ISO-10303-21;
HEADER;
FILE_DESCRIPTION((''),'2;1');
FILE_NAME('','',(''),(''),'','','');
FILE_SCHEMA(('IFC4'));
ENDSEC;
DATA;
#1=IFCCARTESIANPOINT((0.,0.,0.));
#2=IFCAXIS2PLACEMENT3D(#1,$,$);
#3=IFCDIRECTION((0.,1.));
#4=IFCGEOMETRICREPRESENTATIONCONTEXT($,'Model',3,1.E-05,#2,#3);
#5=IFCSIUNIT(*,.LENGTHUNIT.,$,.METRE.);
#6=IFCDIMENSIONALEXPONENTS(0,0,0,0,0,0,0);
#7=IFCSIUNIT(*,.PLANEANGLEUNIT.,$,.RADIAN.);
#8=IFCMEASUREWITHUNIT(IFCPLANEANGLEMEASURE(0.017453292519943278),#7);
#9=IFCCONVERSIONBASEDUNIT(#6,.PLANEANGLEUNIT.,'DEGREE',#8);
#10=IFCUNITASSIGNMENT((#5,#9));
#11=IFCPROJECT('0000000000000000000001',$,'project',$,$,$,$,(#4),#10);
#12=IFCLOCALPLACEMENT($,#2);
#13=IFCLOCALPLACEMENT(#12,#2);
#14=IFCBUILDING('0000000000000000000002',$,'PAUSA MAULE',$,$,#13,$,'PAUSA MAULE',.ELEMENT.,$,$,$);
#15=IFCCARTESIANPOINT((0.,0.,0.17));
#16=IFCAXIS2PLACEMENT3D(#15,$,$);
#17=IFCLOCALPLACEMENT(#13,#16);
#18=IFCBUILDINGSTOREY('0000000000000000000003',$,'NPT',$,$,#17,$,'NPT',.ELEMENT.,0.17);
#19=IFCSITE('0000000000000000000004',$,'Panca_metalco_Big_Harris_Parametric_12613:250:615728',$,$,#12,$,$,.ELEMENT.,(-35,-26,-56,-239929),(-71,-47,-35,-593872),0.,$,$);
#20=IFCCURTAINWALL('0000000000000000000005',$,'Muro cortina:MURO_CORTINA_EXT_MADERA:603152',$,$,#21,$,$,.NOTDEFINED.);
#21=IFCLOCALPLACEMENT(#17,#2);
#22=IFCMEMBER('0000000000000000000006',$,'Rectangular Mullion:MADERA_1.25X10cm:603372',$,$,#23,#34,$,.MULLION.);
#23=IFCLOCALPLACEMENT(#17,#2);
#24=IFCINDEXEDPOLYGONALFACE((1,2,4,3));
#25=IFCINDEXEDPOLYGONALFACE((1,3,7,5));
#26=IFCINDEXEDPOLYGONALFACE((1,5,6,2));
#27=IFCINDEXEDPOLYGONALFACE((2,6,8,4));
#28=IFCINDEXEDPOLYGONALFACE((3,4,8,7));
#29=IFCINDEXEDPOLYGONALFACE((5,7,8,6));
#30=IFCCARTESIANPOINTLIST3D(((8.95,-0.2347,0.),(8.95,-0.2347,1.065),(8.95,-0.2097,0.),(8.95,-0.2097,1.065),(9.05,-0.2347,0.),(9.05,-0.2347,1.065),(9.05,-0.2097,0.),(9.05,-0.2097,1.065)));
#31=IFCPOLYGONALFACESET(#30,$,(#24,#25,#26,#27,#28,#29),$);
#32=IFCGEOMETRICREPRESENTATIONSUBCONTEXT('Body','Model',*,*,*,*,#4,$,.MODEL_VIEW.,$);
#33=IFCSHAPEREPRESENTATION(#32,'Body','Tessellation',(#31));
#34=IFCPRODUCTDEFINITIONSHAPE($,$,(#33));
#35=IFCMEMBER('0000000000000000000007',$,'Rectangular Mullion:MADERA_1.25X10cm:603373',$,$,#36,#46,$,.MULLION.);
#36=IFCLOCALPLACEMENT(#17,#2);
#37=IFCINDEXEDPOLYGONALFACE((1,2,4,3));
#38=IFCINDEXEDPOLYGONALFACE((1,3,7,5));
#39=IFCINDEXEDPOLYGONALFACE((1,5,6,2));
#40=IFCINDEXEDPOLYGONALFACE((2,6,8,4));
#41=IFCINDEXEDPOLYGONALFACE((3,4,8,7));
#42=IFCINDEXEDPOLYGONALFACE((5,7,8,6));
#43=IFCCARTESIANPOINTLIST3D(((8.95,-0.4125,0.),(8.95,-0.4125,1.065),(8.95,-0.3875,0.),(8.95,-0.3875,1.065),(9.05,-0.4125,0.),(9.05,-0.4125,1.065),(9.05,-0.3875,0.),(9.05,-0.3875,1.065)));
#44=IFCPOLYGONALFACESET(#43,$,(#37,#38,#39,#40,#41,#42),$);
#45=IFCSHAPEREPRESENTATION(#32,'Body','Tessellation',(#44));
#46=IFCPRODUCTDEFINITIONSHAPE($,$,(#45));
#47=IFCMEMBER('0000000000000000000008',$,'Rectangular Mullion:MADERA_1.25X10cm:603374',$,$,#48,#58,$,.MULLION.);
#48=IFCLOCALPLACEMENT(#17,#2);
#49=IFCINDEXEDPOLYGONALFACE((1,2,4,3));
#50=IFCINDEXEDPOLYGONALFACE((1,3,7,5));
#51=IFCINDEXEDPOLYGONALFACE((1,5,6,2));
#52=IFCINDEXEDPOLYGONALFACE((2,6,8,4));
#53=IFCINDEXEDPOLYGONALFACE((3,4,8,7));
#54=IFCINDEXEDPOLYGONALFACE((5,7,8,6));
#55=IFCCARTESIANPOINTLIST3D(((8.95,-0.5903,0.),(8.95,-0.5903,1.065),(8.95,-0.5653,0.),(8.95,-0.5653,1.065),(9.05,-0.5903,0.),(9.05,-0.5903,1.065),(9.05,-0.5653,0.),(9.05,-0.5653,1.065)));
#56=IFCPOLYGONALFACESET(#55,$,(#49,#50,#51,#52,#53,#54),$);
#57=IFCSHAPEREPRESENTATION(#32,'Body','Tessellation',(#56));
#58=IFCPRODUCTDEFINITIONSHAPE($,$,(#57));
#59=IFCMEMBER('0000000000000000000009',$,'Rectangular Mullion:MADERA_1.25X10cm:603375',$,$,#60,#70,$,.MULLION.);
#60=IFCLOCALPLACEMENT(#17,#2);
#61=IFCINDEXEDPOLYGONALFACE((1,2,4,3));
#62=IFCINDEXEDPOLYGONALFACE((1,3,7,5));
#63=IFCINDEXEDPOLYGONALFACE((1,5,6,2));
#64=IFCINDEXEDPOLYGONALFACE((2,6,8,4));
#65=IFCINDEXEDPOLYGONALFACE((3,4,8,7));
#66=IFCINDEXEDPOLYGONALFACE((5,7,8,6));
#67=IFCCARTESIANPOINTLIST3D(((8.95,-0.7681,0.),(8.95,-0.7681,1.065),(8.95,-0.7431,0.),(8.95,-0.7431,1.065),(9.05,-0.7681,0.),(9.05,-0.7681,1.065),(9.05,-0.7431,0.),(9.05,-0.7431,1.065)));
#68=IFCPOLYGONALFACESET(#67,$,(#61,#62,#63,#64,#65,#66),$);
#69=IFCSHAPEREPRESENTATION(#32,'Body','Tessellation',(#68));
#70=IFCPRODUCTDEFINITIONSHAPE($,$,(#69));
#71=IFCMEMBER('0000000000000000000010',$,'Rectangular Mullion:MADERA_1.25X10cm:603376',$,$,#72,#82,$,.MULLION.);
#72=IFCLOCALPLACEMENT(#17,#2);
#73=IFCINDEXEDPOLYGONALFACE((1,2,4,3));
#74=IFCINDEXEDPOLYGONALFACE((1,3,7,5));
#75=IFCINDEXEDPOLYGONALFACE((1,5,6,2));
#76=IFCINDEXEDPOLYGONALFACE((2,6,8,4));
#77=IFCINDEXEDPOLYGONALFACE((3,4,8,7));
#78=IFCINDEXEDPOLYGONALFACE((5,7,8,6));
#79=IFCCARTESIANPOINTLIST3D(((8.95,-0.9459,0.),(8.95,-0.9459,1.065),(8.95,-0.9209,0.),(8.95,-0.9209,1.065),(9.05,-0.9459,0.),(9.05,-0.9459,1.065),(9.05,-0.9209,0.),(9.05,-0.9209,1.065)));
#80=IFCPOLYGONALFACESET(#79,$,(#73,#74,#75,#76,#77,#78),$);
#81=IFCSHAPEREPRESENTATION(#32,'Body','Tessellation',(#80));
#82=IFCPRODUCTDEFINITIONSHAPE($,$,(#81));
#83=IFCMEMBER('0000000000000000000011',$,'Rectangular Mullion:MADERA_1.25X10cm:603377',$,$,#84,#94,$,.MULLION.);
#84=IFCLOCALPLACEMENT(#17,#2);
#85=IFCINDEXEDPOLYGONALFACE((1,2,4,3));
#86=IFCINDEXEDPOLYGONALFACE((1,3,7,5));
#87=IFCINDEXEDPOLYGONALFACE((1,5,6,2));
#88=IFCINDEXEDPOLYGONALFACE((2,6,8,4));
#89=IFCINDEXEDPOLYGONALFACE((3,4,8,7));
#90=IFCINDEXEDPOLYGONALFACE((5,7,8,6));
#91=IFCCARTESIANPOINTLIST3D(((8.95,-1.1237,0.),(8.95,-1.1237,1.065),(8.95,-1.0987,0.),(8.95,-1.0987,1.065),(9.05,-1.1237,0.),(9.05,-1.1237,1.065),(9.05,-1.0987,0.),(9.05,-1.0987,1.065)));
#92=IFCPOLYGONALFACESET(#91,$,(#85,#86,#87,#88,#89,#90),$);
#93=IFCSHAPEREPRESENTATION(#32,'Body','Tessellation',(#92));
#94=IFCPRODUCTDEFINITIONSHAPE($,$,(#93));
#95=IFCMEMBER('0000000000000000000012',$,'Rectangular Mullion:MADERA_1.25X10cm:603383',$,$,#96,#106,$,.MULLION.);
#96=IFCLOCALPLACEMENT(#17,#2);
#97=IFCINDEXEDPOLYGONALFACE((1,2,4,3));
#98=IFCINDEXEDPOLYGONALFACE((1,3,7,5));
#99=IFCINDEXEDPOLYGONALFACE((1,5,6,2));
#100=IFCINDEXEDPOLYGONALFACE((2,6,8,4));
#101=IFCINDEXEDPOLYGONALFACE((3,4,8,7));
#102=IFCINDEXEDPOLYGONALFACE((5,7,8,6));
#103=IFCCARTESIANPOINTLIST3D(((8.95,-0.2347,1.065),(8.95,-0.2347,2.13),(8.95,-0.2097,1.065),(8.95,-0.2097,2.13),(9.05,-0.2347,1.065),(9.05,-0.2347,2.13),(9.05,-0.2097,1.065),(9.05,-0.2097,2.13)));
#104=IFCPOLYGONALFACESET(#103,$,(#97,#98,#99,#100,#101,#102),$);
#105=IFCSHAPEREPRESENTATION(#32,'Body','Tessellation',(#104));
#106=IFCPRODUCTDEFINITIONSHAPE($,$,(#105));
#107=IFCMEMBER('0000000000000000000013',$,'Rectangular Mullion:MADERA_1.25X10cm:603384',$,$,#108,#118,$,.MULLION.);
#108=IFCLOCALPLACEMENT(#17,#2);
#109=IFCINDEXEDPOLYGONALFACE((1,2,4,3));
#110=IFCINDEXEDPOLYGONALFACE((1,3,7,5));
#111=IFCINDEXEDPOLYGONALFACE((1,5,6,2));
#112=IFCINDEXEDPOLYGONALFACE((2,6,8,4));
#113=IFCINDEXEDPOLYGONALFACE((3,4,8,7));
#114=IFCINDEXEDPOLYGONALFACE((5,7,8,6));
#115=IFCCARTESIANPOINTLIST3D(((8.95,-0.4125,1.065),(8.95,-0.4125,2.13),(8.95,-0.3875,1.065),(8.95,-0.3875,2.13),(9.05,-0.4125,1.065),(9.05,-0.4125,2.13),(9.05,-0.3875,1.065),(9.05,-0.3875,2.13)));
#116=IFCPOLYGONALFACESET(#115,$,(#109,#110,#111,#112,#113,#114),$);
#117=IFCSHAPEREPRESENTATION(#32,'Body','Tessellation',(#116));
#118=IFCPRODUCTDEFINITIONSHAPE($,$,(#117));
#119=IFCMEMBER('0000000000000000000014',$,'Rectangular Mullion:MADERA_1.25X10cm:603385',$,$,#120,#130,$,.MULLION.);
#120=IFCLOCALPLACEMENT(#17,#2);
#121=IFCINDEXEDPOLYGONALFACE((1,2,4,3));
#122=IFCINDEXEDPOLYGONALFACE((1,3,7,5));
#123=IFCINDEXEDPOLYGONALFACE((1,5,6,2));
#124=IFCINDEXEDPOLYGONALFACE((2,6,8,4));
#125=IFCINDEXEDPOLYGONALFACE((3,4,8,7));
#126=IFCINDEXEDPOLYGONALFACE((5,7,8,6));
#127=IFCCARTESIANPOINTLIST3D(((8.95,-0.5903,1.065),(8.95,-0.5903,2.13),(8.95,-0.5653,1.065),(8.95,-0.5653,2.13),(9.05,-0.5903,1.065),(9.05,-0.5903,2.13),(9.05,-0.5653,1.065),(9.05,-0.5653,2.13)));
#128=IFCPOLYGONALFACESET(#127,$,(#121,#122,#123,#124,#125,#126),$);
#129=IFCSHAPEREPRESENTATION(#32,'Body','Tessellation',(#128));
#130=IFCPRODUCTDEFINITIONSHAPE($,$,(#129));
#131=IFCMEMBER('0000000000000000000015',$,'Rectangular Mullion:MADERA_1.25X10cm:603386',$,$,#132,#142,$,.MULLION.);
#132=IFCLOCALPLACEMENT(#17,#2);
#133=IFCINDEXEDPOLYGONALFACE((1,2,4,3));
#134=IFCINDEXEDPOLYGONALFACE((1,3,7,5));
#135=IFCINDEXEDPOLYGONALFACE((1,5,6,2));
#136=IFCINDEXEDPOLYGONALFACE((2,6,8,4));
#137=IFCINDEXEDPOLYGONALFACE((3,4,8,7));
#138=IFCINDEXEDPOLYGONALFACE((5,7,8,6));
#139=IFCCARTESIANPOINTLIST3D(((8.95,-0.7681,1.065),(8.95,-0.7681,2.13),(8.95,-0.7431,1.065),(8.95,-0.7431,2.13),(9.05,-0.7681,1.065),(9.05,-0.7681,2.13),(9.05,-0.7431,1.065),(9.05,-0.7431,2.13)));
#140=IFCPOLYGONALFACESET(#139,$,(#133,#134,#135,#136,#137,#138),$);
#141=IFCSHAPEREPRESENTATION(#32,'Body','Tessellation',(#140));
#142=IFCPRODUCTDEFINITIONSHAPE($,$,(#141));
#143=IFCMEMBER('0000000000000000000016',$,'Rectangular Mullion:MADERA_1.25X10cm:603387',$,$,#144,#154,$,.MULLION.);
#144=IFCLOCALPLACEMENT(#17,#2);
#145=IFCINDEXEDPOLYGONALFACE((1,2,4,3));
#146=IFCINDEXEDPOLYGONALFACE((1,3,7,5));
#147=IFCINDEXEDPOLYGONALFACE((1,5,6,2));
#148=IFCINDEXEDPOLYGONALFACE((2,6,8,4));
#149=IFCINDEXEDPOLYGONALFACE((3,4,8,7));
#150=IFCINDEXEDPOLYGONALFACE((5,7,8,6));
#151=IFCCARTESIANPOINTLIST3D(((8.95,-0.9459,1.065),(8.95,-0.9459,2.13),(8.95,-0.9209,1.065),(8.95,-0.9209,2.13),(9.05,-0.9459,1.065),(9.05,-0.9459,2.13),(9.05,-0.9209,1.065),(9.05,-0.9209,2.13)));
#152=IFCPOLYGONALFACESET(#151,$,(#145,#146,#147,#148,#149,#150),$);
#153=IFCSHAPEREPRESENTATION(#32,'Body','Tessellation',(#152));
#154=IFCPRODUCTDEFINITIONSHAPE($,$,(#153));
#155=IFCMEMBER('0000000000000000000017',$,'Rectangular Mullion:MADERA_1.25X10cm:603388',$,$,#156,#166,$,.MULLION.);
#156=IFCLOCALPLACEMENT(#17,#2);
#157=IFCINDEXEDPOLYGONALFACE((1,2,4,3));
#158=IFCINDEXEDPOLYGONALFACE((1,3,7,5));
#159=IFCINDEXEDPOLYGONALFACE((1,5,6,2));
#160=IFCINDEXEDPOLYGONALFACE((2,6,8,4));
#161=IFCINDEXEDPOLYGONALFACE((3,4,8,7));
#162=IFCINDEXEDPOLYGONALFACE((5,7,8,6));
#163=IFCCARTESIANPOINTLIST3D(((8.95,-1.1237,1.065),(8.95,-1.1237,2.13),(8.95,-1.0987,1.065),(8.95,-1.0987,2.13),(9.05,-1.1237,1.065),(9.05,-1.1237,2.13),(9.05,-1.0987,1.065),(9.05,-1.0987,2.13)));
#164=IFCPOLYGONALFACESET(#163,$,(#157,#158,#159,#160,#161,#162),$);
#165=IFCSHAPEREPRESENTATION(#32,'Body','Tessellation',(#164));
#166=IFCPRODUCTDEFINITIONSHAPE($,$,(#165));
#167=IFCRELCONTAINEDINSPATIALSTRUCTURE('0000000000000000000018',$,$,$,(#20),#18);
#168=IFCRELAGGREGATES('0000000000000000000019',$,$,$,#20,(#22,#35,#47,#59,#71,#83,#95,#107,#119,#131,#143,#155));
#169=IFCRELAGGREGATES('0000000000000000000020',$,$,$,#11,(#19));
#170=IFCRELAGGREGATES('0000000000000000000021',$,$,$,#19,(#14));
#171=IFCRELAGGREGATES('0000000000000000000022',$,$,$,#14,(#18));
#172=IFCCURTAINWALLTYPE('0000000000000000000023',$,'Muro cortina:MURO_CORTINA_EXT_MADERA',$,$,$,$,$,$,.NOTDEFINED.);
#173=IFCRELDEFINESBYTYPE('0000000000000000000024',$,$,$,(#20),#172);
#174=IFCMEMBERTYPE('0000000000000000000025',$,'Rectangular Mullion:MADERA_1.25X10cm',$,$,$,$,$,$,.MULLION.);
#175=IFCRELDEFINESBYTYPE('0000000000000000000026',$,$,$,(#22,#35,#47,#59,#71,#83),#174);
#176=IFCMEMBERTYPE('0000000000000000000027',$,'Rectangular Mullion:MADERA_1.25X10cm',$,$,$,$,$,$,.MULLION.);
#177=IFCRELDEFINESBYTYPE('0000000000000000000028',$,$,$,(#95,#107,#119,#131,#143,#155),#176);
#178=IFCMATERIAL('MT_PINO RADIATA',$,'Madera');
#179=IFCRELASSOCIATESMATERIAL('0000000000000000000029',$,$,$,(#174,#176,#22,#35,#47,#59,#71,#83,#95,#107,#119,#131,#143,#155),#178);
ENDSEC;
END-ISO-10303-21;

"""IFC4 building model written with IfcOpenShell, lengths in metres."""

from ifc_helpers import new_model, entity, si_unit, converted_unit, direction, frame, frame_2d, origin, place, context, subcontext, project, spatial, rectangle, extrude, source, transform, mapped, material, material_profile, profile_set, profile_usage, type_object, type_shapes, element, aggregate, save


model = new_model("IFC4")

# Units and contexts
model_context = context("Model", 3, precision=1e-05, world=origin(), true_north=direction((0.0, 1.0)))
body_context = subcontext(model_context, "Body", "Model", "MODEL_VIEW")
ifc_project = project(units=[si_unit("LENGTHUNIT", "METRE"), converted_unit("PLANEANGLEUNIT", "DEGREE", entity("IfcPlaneAngleMeasure", 0.017453292519943278), si_unit("PLANEANGLEUNIT", "RADIAN"), dimensions=[0, 0, 0, 0, 0, 0, 0])], contexts=[model_context])

# Site, building, storey
site_placement = place(None, origin())
site = spatial("IfcSite", under=ifc_project, at=site_placement, Name="Panca_metalco_Big_Harris_Parametric_12613:250:615728", CompositionType="ELEMENT", RefLatitude=(-35, -26, -56, -239929), RefLongitude=(-71, -47, -35, -593872), RefElevation=0.0)
building_placement = place(site_placement, origin())
building = spatial("IfcBuilding", under=site, at=building_placement, Name="PAUSA MAULE", LongName="PAUSA MAULE", CompositionType="ELEMENT")
storey_placement = place(building_placement, frame((0.0, 0.0, 0.17)))
storey = spatial("IfcBuildingStorey", under=building, at=storey_placement, Name="NPT", LongName="NPT", CompositionType="ELEMENT", Elevation=0.17)

# Curtain wall, members
curtain_wall_type = type_object("IfcCurtainWallType", Name="Muro cortina:MURO_CORTINA_EXT_MADERA", PredefinedType="NOTDEFINED")
curtain_wall_placement = place(storey_placement, frame((0.0, 0.0, -0.17)))
curtain_wall = element("IfcCurtainWall", 1, at=curtain_wall_placement, inside=storey, type_object=curtain_wall_type, Name="Muro cortina:MURO_CORTINA_EXT_MADERA:603152", PredefinedType="NOTDEFINED")
ifc_material = material(Name="MT_PINO RADIATA", Category="Madera")
ifc_material_profile = material_profile(ifc_material, rectangle(XDim=0.025, YDim=0.1, at=frame_2d((0.0, 0.0), x_axis=(1.0, 0.0))), Name="MADERA_1.25X10cm")
ifc_profile_set = profile_set([ifc_material_profile], Name="MADERA_1.25X10cm")
ifc_profile_usage = profile_usage(ifc_profile_set)
member_type_1 = type_object("IfcMemberType", Name="Rectangular Mullion:MADERA_1.25X10cm", PredefinedType="MULLION", material=ifc_profile_set)
shared_shape_1 = source(origin(), body_context, "Body", "SweptSolid", [
    extrude(rectangle(XDim=0.025, YDim=0.1, at=frame_2d((0.0, 0.0), x_axis=(1.0, 0.0))), frame((0.0, 0.0, -1.065), z_axis=(0.0, 0.0, 1.0), x_axis=(-1.0, 0.0, 0.0)), (0.0, 0.0, 1.0), 1.065),
])
type_shapes(member_type_1, [shared_shape_1])
member_1_placement = place(curtain_wall_placement, frame((9.0, -0.2222, 0.17), z_axis=(0.0, 0.0, -1.0), x_axis=(0.0, -1.0, 0.0)))
member_1 = element("IfcMember", 2, at=member_1_placement, type_object=member_type_1, material=ifc_profile_usage, Name="Rectangular Mullion:MADERA_1.25X10cm:603372", PredefinedType="MULLION", context=body_context, shape_type="MappedRepresentation", body=[
    mapped(shared_shape_1, transform((0.0, 0.0, 0.0), scale=1.0)),
])
member_2_placement = place(curtain_wall_placement, frame((9.0, -0.4, 0.17), z_axis=(0.0, 0.0, -1.0), x_axis=(0.0, -1.0, 0.0)))
member_2 = element("IfcMember", 3, at=member_2_placement, type_object=member_type_1, material=ifc_profile_usage, Name="Rectangular Mullion:MADERA_1.25X10cm:603373", PredefinedType="MULLION", context=body_context, shape_type="MappedRepresentation", body=[
    mapped(shared_shape_1, transform((0.0, 0.0, 0.0), scale=1.0)),
])
member_3_placement = place(curtain_wall_placement, frame((9.0, -0.5778, 0.17), z_axis=(0.0, 0.0, -1.0), x_axis=(0.0, -1.0, 0.0)))
member_3 = element("IfcMember", 4, at=member_3_placement, type_object=member_type_1, material=ifc_profile_usage, Name="Rectangular Mullion:MADERA_1.25X10cm:603374", PredefinedType="MULLION", context=body_context, shape_type="MappedRepresentation", body=[
    mapped(shared_shape_1, transform((0.0, 0.0, 0.0), scale=1.0)),
])
member_4_placement = place(curtain_wall_placement, frame((9.0, -0.7556, 0.17), z_axis=(0.0, 0.0, -1.0), x_axis=(0.0, -1.0, 0.0)))
member_4 = element("IfcMember", 5, at=member_4_placement, type_object=member_type_1, material=ifc_profile_usage, Name="Rectangular Mullion:MADERA_1.25X10cm:603375", PredefinedType="MULLION", context=body_context, shape_type="MappedRepresentation", body=[
    mapped(shared_shape_1, transform((0.0, 0.0, 0.0), scale=1.0)),
])
member_5_placement = place(curtain_wall_placement, frame((9.0, -0.9334, 0.17), z_axis=(0.0, 0.0, -1.0), x_axis=(0.0, -1.0, 0.0)))
member_5 = element("IfcMember", 6, at=member_5_placement, type_object=member_type_1, material=ifc_profile_usage, Name="Rectangular Mullion:MADERA_1.25X10cm:603376", PredefinedType="MULLION", context=body_context, shape_type="MappedRepresentation", body=[
    mapped(shared_shape_1, transform((0.0, 0.0, 0.0), scale=1.0)),
])
member_6_placement = place(curtain_wall_placement, frame((9.0, -1.1112, 0.17), z_axis=(0.0, 0.0, -1.0), x_axis=(0.0, -1.0, 0.0)))
member_6 = element("IfcMember", 7, at=member_6_placement, type_object=member_type_1, material=ifc_profile_usage, Name="Rectangular Mullion:MADERA_1.25X10cm:603377", PredefinedType="MULLION", context=body_context, shape_type="MappedRepresentation", body=[
    mapped(shared_shape_1, transform((0.0, 0.0, 0.0), scale=1.0)),
])
member_type_2 = type_object("IfcMemberType", Name="Rectangular Mullion:MADERA_1.25X10cm", PredefinedType="MULLION", material=ifc_profile_set)
shared_shape_2 = source(origin(), body_context, "Body", "SweptSolid", [
    extrude(rectangle(XDim=0.025, YDim=0.1, at=frame_2d((0.0, 0.0), x_axis=(1.0, 0.0))), frame((0.0, 0.0, -1.065), z_axis=(0.0, 0.0, 1.0), x_axis=(-1.0, 0.0, 0.0)), (0.0, 0.0, 1.0), 1.065),
])
type_shapes(member_type_2, [shared_shape_2])
member_7_placement = place(curtain_wall_placement, frame((9.0, -0.2222, 1.235), z_axis=(0.0, 0.0, -1.0), x_axis=(0.0, -1.0, 0.0)))
member_7 = element("IfcMember", 8, at=member_7_placement, type_object=member_type_2, material=ifc_profile_usage, Name="Rectangular Mullion:MADERA_1.25X10cm:603383", PredefinedType="MULLION", context=body_context, shape_type="MappedRepresentation", body=[
    mapped(shared_shape_2, transform((0.0, 0.0, 0.0), scale=1.0)),
])
member_8_placement = place(curtain_wall_placement, frame((9.0, -0.4, 1.235), z_axis=(0.0, 0.0, -1.0), x_axis=(0.0, -1.0, 0.0)))
member_8 = element("IfcMember", 9, at=member_8_placement, type_object=member_type_2, material=ifc_profile_usage, Name="Rectangular Mullion:MADERA_1.25X10cm:603384", PredefinedType="MULLION", context=body_context, shape_type="MappedRepresentation", body=[
    mapped(shared_shape_2, transform((0.0, 0.0, 0.0), scale=1.0)),
])
member_9_placement = place(curtain_wall_placement, frame((9.0, -0.5778, 1.235), z_axis=(0.0, 0.0, -1.0), x_axis=(0.0, -1.0, 0.0)))
member_9 = element("IfcMember", 10, at=member_9_placement, type_object=member_type_2, material=ifc_profile_usage, Name="Rectangular Mullion:MADERA_1.25X10cm:603385", PredefinedType="MULLION", context=body_context, shape_type="MappedRepresentation", body=[
    mapped(shared_shape_2, transform((0.0, 0.0, 0.0), scale=1.0)),
])
member_10_placement = place(curtain_wall_placement, frame((9.0, -0.7556, 1.235), z_axis=(0.0, 0.0, -1.0), x_axis=(0.0, -1.0, 0.0)))
member_10 = element("IfcMember", 11, at=member_10_placement, type_object=member_type_2, material=ifc_profile_usage, Name="Rectangular Mullion:MADERA_1.25X10cm:603386", PredefinedType="MULLION", context=body_context, shape_type="MappedRepresentation", body=[
    mapped(shared_shape_2, transform((0.0, 0.0, 0.0), scale=1.0)),
])
member_11_placement = place(curtain_wall_placement, frame((9.0, -0.9334, 1.235), z_axis=(0.0, 0.0, -1.0), x_axis=(0.0, -1.0, 0.0)))
member_11 = element("IfcMember", 12, at=member_11_placement, type_object=member_type_2, material=ifc_profile_usage, Name="Rectangular Mullion:MADERA_1.25X10cm:603387", PredefinedType="MULLION", context=body_context, shape_type="MappedRepresentation", body=[
    mapped(shared_shape_2, transform((0.0, 0.0, 0.0), scale=1.0)),
])
member_12_placement = place(curtain_wall_placement, frame((9.0, -1.1112, 1.235), z_axis=(0.0, 0.0, -1.0), x_axis=(0.0, -1.0, 0.0)))
member_12 = element("IfcMember", 13, at=member_12_placement, type_object=member_type_2, material=ifc_profile_usage, Name="Rectangular Mullion:MADERA_1.25X10cm:603388", PredefinedType="MULLION", context=body_context, shape_type="MappedRepresentation", body=[
    mapped(shared_shape_2, transform((0.0, 0.0, 0.0), scale=1.0)),
])
aggregate(curtain_wall, [member_1, member_2, member_3, member_4, member_5, member_6, member_7, member_8, member_9, member_10, member_11, member_12])

save(model, "model.ifc")
